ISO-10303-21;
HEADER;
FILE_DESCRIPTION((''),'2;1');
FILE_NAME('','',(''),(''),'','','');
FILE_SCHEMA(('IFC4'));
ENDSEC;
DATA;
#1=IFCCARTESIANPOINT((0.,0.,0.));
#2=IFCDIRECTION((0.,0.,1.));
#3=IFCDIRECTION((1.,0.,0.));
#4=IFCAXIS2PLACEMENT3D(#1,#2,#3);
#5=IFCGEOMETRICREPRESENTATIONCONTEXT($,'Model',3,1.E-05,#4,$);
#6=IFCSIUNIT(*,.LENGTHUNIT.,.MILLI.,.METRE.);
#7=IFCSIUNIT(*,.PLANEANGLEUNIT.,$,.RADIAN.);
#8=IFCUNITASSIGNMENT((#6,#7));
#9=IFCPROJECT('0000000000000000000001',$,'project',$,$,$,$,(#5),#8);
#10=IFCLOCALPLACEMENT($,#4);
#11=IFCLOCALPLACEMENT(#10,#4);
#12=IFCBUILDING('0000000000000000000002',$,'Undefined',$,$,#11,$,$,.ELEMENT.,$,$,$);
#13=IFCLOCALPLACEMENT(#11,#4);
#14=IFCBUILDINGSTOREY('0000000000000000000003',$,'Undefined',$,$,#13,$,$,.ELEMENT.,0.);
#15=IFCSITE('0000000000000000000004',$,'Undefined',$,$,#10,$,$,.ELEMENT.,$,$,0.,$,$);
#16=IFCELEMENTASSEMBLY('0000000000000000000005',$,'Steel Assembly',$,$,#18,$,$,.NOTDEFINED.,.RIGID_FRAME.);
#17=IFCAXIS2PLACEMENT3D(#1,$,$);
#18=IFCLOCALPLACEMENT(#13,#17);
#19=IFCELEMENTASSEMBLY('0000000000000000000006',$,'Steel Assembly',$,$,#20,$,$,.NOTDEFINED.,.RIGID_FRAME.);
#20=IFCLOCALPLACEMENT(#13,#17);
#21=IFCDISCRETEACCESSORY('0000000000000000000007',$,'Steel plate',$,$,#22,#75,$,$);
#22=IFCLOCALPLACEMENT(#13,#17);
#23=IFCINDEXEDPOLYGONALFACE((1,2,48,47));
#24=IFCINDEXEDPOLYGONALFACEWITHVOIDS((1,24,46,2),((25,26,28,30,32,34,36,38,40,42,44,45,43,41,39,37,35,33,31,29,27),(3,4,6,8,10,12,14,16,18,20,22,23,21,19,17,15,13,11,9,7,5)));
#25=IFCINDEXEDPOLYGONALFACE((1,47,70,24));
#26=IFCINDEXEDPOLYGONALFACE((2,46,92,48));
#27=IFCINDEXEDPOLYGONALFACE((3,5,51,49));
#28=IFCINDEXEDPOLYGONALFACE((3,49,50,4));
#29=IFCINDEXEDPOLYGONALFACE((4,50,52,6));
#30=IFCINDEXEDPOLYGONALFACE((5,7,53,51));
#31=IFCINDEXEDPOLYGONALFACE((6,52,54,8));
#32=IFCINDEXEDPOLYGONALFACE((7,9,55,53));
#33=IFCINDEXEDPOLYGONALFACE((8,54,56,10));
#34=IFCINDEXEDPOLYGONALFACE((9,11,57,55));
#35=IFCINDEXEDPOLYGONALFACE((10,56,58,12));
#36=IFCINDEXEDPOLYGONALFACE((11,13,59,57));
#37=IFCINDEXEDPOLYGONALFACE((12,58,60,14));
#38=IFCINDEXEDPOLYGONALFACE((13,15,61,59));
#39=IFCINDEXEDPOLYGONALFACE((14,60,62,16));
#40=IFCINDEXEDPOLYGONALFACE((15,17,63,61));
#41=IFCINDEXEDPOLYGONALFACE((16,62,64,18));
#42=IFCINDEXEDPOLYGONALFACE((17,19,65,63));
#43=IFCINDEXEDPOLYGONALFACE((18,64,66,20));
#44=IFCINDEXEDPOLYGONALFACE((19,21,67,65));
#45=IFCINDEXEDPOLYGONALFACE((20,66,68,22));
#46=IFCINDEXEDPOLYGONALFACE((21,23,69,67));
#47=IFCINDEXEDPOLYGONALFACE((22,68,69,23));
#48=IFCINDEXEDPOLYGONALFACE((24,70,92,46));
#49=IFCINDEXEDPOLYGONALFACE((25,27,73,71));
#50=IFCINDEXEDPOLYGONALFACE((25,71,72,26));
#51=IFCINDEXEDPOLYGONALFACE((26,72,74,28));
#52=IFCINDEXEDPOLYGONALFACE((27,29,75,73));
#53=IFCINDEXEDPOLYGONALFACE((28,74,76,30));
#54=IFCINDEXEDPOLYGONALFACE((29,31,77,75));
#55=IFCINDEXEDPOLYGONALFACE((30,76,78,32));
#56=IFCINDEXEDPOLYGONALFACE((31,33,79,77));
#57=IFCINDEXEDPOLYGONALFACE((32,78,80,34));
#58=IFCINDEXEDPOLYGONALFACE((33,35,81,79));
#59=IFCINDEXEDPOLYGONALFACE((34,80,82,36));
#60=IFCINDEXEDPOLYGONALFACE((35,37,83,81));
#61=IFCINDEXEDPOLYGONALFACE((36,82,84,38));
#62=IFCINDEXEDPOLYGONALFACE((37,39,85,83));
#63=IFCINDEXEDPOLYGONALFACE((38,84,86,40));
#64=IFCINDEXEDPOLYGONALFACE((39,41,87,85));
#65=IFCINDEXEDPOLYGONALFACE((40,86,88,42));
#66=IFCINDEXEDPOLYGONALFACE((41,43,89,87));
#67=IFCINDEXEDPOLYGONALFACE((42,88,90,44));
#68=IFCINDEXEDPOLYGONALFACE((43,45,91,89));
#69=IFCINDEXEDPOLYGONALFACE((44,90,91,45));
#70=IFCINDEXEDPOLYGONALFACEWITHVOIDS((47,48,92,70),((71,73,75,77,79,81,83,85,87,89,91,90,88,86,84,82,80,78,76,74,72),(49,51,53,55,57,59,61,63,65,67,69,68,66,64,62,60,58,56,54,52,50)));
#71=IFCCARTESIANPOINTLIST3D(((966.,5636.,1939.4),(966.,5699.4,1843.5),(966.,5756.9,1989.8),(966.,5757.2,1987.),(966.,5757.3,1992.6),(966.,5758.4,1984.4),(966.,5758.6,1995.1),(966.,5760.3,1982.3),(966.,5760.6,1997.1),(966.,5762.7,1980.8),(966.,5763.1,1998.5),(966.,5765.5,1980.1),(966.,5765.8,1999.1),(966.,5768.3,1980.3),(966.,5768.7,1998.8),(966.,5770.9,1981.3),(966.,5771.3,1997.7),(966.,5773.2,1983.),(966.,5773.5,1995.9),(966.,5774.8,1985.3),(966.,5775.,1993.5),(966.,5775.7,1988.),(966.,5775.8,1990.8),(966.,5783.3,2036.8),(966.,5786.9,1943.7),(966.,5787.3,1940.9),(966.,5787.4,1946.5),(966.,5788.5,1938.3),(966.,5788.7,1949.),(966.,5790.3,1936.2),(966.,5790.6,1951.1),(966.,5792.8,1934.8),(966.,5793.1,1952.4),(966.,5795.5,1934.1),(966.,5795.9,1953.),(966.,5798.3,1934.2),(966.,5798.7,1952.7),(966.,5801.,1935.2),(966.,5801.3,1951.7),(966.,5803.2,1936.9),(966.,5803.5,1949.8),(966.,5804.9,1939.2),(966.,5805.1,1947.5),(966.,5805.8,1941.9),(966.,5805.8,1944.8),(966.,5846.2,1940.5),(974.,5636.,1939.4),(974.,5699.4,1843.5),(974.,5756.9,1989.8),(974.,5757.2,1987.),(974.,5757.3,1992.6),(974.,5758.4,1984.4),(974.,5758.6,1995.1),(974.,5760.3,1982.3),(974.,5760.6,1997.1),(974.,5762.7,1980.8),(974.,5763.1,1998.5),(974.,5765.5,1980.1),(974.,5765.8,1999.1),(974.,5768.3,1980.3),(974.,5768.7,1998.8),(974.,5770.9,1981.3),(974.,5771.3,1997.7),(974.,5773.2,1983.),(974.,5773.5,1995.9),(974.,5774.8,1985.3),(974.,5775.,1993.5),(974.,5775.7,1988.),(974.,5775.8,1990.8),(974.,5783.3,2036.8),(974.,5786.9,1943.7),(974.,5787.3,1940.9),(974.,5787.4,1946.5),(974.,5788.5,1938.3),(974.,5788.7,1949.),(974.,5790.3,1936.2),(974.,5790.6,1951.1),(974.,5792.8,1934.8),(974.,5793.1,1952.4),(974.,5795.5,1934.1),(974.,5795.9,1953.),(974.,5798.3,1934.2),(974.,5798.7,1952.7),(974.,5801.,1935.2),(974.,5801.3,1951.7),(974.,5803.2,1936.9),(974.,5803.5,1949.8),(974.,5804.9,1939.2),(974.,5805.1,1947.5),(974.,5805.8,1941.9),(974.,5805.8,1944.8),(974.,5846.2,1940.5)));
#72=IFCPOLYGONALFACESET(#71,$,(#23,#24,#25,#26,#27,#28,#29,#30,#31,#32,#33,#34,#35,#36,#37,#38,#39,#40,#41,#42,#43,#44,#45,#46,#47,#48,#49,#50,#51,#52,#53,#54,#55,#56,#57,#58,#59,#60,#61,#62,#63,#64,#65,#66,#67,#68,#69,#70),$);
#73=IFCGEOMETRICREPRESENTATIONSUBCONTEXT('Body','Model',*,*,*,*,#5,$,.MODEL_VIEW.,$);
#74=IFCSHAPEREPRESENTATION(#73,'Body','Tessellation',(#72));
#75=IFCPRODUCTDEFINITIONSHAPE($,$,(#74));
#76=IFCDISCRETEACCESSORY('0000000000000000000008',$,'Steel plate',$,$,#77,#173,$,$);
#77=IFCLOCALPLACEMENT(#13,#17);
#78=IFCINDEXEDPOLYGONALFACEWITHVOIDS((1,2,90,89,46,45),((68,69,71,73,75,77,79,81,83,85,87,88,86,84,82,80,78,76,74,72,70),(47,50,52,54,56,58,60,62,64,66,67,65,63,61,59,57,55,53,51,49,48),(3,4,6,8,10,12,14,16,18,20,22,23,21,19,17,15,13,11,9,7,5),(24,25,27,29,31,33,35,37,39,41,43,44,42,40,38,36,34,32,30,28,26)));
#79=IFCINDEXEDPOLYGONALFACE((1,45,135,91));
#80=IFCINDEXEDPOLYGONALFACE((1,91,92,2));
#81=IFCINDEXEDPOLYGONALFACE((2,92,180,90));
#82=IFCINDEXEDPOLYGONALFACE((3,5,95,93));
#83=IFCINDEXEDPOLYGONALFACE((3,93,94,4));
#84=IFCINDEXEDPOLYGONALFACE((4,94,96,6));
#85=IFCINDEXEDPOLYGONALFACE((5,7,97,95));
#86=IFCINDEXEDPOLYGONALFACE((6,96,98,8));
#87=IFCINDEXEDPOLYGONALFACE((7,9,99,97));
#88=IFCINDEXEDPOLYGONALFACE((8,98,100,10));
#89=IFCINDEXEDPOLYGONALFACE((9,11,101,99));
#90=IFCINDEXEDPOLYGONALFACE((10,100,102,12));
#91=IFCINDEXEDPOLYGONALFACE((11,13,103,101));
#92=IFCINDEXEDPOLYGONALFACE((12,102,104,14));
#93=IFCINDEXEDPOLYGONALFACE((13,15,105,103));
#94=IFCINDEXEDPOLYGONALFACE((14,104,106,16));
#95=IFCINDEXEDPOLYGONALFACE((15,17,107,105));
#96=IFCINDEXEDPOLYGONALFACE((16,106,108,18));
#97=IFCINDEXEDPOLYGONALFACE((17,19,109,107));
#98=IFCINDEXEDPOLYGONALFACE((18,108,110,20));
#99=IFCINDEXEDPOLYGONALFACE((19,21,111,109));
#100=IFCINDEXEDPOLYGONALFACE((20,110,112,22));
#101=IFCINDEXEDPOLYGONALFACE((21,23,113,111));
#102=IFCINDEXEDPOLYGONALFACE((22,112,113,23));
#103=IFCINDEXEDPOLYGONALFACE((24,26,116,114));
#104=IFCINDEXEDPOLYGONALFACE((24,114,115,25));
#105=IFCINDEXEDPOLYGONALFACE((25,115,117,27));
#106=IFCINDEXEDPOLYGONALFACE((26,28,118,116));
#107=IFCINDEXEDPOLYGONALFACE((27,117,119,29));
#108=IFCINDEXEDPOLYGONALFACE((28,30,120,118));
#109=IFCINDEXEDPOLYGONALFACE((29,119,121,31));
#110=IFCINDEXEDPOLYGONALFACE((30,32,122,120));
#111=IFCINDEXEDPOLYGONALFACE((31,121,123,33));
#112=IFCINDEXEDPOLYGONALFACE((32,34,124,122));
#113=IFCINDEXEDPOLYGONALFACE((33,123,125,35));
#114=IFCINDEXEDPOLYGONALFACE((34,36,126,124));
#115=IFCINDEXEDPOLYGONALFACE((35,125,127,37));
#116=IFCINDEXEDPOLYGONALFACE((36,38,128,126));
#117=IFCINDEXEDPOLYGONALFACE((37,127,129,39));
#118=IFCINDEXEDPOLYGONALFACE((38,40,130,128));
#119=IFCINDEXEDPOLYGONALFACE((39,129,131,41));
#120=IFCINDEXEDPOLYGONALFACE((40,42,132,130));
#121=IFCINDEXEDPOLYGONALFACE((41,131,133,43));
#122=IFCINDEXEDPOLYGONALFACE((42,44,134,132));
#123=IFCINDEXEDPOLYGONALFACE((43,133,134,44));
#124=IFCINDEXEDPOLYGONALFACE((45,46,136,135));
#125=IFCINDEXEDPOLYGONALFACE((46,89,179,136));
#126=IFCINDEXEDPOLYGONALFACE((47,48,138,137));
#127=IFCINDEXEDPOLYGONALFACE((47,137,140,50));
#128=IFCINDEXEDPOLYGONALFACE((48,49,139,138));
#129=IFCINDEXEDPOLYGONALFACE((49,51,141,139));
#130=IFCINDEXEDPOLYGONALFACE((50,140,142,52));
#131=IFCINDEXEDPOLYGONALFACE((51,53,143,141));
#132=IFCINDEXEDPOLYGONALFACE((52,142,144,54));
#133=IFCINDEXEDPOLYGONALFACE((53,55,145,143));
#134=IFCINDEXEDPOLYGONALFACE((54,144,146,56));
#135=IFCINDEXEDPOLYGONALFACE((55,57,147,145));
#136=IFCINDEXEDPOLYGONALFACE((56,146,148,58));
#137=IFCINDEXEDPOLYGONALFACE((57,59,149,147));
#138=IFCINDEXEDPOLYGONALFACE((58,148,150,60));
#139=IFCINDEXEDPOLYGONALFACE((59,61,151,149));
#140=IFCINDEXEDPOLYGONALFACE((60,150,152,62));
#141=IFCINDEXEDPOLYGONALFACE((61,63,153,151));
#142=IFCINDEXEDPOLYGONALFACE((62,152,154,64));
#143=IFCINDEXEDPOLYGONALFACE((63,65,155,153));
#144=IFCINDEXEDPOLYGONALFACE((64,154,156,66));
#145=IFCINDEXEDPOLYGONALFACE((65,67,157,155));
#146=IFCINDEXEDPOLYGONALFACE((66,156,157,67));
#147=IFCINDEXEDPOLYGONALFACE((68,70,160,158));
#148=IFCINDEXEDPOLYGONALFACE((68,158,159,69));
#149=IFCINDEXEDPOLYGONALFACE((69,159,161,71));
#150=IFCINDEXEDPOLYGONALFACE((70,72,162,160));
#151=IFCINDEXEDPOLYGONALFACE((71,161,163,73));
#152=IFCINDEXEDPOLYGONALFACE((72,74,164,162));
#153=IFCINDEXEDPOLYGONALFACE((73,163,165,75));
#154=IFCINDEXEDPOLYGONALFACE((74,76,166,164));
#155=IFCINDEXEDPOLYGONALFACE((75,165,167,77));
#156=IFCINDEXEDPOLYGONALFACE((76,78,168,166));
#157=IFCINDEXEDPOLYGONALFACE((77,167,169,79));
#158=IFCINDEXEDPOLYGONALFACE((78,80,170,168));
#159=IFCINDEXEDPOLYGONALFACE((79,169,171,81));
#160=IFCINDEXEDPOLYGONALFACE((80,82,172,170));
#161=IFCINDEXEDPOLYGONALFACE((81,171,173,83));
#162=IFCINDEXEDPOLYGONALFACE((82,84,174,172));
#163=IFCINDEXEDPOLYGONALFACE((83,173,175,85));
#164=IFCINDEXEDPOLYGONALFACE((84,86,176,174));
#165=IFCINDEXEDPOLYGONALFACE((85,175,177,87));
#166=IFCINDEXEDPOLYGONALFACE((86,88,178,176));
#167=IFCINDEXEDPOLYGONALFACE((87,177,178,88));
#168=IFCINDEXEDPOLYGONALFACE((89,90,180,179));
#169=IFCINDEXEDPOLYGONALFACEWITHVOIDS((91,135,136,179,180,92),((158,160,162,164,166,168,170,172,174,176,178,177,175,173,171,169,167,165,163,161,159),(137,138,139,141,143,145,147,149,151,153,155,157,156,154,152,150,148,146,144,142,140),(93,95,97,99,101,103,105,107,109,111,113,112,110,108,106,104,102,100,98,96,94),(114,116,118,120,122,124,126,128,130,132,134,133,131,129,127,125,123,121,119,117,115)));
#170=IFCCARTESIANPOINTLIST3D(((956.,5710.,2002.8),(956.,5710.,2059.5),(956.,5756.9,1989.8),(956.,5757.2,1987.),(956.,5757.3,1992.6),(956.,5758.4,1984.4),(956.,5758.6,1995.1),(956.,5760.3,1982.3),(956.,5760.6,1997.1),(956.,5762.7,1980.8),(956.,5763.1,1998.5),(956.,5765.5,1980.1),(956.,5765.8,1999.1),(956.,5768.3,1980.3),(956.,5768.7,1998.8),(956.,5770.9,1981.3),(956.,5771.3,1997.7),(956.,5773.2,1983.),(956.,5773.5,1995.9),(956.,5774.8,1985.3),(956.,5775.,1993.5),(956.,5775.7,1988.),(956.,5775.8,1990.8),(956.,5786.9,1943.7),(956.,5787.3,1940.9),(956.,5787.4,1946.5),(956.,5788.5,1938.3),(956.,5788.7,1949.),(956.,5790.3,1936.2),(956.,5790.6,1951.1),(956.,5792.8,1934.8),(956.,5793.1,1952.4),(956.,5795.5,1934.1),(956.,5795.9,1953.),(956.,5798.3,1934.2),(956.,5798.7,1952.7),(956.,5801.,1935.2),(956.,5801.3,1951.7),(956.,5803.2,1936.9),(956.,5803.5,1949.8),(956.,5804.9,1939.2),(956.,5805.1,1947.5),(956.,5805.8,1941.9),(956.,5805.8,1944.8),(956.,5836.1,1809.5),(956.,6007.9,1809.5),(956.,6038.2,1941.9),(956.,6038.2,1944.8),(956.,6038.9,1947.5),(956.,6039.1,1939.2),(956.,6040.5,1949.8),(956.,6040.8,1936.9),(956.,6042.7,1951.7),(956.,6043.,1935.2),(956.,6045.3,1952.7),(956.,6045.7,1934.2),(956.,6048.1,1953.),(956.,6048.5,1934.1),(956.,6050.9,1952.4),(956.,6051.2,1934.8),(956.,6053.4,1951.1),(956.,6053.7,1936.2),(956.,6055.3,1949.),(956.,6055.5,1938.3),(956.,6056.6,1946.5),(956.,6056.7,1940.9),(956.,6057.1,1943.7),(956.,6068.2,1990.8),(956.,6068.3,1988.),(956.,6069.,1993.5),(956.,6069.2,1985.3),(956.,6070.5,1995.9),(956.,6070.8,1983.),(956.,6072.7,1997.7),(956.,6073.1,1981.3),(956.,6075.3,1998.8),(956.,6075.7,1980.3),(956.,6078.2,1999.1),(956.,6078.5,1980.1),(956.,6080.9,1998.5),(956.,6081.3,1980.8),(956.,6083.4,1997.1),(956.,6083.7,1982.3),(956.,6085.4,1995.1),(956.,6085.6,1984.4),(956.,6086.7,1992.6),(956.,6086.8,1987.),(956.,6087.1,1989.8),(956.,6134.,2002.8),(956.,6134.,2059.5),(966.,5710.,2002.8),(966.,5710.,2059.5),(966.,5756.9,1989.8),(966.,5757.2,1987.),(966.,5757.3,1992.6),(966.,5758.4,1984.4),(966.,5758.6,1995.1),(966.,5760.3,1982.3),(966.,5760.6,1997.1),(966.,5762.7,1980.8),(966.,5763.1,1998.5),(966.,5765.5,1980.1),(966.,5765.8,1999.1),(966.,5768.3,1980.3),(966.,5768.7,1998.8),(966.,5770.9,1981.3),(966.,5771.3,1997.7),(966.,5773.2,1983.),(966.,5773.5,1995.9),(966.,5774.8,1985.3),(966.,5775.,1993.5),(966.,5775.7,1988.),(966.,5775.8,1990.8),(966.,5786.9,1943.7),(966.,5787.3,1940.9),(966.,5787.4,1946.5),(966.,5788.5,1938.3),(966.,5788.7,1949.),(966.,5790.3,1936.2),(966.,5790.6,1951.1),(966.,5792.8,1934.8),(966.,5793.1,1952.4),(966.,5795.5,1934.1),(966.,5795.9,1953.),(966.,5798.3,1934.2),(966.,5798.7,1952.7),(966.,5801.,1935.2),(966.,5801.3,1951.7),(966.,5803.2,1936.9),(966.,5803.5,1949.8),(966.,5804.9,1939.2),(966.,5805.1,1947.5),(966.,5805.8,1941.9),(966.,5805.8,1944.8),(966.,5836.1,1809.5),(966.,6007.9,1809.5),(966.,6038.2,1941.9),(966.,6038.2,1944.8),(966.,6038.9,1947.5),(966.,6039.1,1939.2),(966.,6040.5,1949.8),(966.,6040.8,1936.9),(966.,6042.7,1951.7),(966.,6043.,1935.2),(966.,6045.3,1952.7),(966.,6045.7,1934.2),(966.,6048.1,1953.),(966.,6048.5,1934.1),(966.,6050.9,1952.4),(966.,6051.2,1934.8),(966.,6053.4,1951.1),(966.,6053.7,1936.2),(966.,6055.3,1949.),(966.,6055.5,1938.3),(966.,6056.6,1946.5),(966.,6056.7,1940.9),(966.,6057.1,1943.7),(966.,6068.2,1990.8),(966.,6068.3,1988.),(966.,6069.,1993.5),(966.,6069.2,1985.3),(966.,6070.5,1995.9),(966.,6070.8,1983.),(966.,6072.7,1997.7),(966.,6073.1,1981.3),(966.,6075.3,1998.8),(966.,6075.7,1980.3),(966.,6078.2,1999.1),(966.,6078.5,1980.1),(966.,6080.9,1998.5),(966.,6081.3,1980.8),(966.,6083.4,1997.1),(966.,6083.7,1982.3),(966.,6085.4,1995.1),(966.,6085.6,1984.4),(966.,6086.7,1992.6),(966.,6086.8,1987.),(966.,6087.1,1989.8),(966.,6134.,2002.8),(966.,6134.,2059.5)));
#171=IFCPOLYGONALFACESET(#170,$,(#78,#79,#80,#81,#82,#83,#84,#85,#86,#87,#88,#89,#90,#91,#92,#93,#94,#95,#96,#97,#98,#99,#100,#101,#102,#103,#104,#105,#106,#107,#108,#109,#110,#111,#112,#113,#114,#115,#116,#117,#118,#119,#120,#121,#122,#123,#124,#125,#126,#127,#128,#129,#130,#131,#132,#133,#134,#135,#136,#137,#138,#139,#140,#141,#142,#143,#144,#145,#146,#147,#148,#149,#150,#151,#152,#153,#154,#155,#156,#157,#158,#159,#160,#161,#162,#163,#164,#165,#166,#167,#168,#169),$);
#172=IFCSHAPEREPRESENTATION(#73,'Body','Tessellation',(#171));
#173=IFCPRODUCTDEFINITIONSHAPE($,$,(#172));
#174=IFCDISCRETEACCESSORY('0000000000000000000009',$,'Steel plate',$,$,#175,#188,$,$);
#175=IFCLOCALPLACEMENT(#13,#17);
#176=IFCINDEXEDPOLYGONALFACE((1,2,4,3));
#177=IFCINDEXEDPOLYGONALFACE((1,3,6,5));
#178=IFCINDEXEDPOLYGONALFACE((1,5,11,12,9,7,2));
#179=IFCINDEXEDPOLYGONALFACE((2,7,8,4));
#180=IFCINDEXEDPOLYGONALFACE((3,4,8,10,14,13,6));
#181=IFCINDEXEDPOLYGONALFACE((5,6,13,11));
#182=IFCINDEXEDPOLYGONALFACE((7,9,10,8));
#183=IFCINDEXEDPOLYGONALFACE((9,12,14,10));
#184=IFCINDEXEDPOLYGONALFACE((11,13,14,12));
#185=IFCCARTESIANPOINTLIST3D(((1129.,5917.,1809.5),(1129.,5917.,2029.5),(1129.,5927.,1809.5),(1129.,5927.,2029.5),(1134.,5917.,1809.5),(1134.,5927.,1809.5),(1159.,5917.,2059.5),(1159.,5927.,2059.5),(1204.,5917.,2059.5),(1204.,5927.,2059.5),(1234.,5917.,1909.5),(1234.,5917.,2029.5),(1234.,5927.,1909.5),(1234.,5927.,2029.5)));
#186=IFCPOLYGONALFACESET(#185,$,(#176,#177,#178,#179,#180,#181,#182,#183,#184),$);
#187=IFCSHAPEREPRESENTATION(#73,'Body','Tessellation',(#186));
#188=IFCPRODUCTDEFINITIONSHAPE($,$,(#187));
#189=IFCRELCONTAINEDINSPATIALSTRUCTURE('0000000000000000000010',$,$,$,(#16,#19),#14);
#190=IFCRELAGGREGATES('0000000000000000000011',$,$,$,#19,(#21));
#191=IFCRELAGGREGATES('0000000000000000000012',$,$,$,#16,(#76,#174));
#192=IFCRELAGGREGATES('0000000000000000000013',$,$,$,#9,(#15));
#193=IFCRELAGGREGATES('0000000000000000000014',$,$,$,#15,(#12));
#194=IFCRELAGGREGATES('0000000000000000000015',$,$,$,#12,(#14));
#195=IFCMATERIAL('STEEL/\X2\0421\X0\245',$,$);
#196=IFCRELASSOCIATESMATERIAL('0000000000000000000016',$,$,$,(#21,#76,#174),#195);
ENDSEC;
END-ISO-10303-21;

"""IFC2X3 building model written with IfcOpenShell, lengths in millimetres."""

from ifc_helpers import new_model, si_unit, frame, origin_with_axes, origin_2d_with_axis, place, context, subcontext, project, spatial, polyline, circle, outline, extrude, source, transform, mapped, material, element, aggregate, save


model = new_model("IFC2X3")

# Units and contexts
model_context = context("Model", 3, precision=1e-05, world=origin_with_axes())
body_context = subcontext(model_context, "Body", "Model", "MODEL_VIEW")
ifc_project = project(units=[si_unit("LENGTHUNIT", "METRE", prefix="MILLI"), si_unit("PLANEANGLEUNIT", "RADIAN")], contexts=[model_context])

# Site, building, storey
site_placement = place(None, origin_with_axes())
site = spatial("IfcSite", under=ifc_project, at=site_placement, Name="Undefined", CompositionType="ELEMENT", RefElevation=0.0)
building_placement = place(site_placement, origin_with_axes())
building = spatial("IfcBuilding", under=site, at=building_placement, Name="Undefined", CompositionType="ELEMENT")
storey_placement = place(building_placement, origin_with_axes())
storey = spatial("IfcBuildingStorey", under=building, at=storey_placement, Name="Undefined", CompositionType="ELEMENT", Elevation=0.0)

# Element assembly
assembly_1_placement = place(storey_placement, origin_with_axes())
assembly_1 = element("IfcElementAssembly", 1, at=assembly_1_placement, inside=storey, Name="Steel Assembly", AssemblyPlace="NOTDEFINED", PredefinedType="RIGID_FRAME")
ifc_material_1 = material(Name="STEEL/С245")

# Element assembly, discrete accessory, opening
shared_shape_1 = source(origin_with_axes(), body_context, "Body", "SweptSolid", [
    extrude(circle(Radius=9.5, at=origin_2d_with_axis()), frame((0.0, -4.1, 0.0), z_axis=(0.0, 1.0, 0.0), x_axis=(1.0, 0.0, 0.0)), (0.0, 0.0, 1.0), 12.3),
])
assembly_2_placement = place(storey_placement, origin_with_axes())
assembly_2 = element("IfcElementAssembly", 2, at=assembly_2_placement, inside=storey, Name="Steel Assembly", AssemblyPlace="NOTDEFINED", PredefinedType="RIGID_FRAME")
discrete_accessory_1_placement = place(assembly_2_placement, frame((970.0, 5783.3, 2036.8), z_axis=(-1.0, 0.0, 0.0), x_axis=(0.0, 0.546313, -0.837581)))
discrete_accessory_1 = element("IfcDiscreteAccessory", 3, at=discrete_accessory_1_placement, material=ifc_material_1, Name="Steel plate", context=body_context, shape_type="SweptSolid", body=[
    extrude(outline(polyline([(0.0, 0.0), (115.0, 0.0), (116.1, 175.9), (1.1, 176.6), (0.0, 0.0)])), frame((0.0, 0.0, -4.0), z_axis=(0.0, 0.0, 1.0), x_axis=(1.0, 0.0, 0.0)), (0.0, 0.0, 1.0), 8.0),
])
opening_1_placement = place(assembly_2_placement, frame((970.0, 5781.4, 1966.6), z_axis=(0.0, -0.546313, 0.837581), x_axis=(0.0, -0.837581, -0.546313)))
element("IfcOpeningElement", 4, at=opening_1_placement, cuts=discrete_accessory_1, ObjectType="Opening", context=body_context, shape_type="MappedRepresentation", body=[
    mapped(shared_shape_1, transform((0.0, 0.0, -27.5))),
    mapped(shared_shape_1, transform((0.0, 0.0, 27.5))),
])
aggregate(assembly_2, [discrete_accessory_1])

# Discrete accessory, openings
discrete_accessory_2_placement = place(assembly_1_placement, frame((961.0, 6134.0, 2059.5), z_axis=(1.0, 0.0, 0.0), x_axis=(0.0, -1.0, 0.0)))
discrete_accessory_2 = element("IfcDiscreteAccessory", 5, at=discrete_accessory_2_placement, material=ifc_material_1, Name="Steel plate", context=body_context, shape_type="SweptSolid", body=[
    extrude(outline(polyline([(0.0, 0.0), (424.0, 0.0), (424.0, 56.7), (297.9, 250.0), (126.1, 250.0), (0.0, 56.7), (0.0, 0.0)])), frame((0.0, 0.0, -5.0), z_axis=(0.0, 0.0, 1.0), x_axis=(1.0, 0.0, 0.0)), (0.0, 0.0, 1.0), 10.0),
])
shared_shape_2 = source(origin_with_axes(), body_context, "Body", "SweptSolid", [
    extrude(circle(Radius=9.5, at=origin_2d_with_axis()), frame((0.0, 3.9, 0.0), z_axis=(0.0, 1.0, 0.0), x_axis=(1.0, 0.0, 0.0)), (0.0, 0.0, 1.0), 14.1),
])
opening_2_placement = place(assembly_1_placement, frame((970.0, 6062.6, 1966.6), z_axis=(0.0, 0.546313, 0.837581), x_axis=(0.0, 0.837581, -0.546313)))
element("IfcOpeningElement", 6, at=opening_2_placement, cuts=discrete_accessory_2, ObjectType="Opening", context=body_context, shape_type="MappedRepresentation", body=[
    mapped(shared_shape_2, transform((0.0, 0.0, -27.5))),
    mapped(shared_shape_2, transform((0.0, 0.0, 27.5))),
])
shared_shape_3 = source(origin_with_axes(), body_context, "Body", "SweptSolid", [
    extrude(circle(Radius=9.5, at=origin_2d_with_axis()), frame((0.0, -14.1, 0.0), z_axis=(0.0, 1.0, 0.0), x_axis=(1.0, 0.0, 0.0)), (0.0, 0.0, 1.0), 24.3),
])
opening_3_placement = place(assembly_1_placement, frame((970.0, 5781.4, 1966.6), z_axis=(0.0, -0.546313, 0.837581), x_axis=(0.0, -0.837581, -0.546313)))
element("IfcOpeningElement", 7, at=opening_3_placement, cuts=discrete_accessory_2, ObjectType="Opening", context=body_context, shape_type="MappedRepresentation", body=[
    mapped(shared_shape_3, transform((0.0, 0.0, -27.5))),
    mapped(shared_shape_3, transform((0.0, 0.0, 27.5))),
])

# Discrete accessory
discrete_accessory_3_placement = place(assembly_1_placement, frame((1129.0, 5922.0, 2059.5), z_axis=(0.0, 1.0, 0.0), x_axis=(1.0, 0.0, 0.0)))
discrete_accessory_3 = element("IfcDiscreteAccessory", 8, at=discrete_accessory_3_placement, material=ifc_material_1, Name="Steel plate", context=body_context, shape_type="SweptSolid", body=[
    extrude(outline(polyline([(0.0, 30.0), (30.0, 0.0), (75.0, 0.0), (105.0, 30.0), (105.0, 150.0), (5.0, 250.0), (0.0, 250.0), (0.0, 30.0)])), frame((0.0, 0.0, -5.0), z_axis=(0.0, 0.0, 1.0), x_axis=(1.0, 0.0, 0.0)), (0.0, 0.0, 1.0), 10.0),
])
aggregate(assembly_1, [discrete_accessory_2, discrete_accessory_3])

save(model, "model.ifc")
